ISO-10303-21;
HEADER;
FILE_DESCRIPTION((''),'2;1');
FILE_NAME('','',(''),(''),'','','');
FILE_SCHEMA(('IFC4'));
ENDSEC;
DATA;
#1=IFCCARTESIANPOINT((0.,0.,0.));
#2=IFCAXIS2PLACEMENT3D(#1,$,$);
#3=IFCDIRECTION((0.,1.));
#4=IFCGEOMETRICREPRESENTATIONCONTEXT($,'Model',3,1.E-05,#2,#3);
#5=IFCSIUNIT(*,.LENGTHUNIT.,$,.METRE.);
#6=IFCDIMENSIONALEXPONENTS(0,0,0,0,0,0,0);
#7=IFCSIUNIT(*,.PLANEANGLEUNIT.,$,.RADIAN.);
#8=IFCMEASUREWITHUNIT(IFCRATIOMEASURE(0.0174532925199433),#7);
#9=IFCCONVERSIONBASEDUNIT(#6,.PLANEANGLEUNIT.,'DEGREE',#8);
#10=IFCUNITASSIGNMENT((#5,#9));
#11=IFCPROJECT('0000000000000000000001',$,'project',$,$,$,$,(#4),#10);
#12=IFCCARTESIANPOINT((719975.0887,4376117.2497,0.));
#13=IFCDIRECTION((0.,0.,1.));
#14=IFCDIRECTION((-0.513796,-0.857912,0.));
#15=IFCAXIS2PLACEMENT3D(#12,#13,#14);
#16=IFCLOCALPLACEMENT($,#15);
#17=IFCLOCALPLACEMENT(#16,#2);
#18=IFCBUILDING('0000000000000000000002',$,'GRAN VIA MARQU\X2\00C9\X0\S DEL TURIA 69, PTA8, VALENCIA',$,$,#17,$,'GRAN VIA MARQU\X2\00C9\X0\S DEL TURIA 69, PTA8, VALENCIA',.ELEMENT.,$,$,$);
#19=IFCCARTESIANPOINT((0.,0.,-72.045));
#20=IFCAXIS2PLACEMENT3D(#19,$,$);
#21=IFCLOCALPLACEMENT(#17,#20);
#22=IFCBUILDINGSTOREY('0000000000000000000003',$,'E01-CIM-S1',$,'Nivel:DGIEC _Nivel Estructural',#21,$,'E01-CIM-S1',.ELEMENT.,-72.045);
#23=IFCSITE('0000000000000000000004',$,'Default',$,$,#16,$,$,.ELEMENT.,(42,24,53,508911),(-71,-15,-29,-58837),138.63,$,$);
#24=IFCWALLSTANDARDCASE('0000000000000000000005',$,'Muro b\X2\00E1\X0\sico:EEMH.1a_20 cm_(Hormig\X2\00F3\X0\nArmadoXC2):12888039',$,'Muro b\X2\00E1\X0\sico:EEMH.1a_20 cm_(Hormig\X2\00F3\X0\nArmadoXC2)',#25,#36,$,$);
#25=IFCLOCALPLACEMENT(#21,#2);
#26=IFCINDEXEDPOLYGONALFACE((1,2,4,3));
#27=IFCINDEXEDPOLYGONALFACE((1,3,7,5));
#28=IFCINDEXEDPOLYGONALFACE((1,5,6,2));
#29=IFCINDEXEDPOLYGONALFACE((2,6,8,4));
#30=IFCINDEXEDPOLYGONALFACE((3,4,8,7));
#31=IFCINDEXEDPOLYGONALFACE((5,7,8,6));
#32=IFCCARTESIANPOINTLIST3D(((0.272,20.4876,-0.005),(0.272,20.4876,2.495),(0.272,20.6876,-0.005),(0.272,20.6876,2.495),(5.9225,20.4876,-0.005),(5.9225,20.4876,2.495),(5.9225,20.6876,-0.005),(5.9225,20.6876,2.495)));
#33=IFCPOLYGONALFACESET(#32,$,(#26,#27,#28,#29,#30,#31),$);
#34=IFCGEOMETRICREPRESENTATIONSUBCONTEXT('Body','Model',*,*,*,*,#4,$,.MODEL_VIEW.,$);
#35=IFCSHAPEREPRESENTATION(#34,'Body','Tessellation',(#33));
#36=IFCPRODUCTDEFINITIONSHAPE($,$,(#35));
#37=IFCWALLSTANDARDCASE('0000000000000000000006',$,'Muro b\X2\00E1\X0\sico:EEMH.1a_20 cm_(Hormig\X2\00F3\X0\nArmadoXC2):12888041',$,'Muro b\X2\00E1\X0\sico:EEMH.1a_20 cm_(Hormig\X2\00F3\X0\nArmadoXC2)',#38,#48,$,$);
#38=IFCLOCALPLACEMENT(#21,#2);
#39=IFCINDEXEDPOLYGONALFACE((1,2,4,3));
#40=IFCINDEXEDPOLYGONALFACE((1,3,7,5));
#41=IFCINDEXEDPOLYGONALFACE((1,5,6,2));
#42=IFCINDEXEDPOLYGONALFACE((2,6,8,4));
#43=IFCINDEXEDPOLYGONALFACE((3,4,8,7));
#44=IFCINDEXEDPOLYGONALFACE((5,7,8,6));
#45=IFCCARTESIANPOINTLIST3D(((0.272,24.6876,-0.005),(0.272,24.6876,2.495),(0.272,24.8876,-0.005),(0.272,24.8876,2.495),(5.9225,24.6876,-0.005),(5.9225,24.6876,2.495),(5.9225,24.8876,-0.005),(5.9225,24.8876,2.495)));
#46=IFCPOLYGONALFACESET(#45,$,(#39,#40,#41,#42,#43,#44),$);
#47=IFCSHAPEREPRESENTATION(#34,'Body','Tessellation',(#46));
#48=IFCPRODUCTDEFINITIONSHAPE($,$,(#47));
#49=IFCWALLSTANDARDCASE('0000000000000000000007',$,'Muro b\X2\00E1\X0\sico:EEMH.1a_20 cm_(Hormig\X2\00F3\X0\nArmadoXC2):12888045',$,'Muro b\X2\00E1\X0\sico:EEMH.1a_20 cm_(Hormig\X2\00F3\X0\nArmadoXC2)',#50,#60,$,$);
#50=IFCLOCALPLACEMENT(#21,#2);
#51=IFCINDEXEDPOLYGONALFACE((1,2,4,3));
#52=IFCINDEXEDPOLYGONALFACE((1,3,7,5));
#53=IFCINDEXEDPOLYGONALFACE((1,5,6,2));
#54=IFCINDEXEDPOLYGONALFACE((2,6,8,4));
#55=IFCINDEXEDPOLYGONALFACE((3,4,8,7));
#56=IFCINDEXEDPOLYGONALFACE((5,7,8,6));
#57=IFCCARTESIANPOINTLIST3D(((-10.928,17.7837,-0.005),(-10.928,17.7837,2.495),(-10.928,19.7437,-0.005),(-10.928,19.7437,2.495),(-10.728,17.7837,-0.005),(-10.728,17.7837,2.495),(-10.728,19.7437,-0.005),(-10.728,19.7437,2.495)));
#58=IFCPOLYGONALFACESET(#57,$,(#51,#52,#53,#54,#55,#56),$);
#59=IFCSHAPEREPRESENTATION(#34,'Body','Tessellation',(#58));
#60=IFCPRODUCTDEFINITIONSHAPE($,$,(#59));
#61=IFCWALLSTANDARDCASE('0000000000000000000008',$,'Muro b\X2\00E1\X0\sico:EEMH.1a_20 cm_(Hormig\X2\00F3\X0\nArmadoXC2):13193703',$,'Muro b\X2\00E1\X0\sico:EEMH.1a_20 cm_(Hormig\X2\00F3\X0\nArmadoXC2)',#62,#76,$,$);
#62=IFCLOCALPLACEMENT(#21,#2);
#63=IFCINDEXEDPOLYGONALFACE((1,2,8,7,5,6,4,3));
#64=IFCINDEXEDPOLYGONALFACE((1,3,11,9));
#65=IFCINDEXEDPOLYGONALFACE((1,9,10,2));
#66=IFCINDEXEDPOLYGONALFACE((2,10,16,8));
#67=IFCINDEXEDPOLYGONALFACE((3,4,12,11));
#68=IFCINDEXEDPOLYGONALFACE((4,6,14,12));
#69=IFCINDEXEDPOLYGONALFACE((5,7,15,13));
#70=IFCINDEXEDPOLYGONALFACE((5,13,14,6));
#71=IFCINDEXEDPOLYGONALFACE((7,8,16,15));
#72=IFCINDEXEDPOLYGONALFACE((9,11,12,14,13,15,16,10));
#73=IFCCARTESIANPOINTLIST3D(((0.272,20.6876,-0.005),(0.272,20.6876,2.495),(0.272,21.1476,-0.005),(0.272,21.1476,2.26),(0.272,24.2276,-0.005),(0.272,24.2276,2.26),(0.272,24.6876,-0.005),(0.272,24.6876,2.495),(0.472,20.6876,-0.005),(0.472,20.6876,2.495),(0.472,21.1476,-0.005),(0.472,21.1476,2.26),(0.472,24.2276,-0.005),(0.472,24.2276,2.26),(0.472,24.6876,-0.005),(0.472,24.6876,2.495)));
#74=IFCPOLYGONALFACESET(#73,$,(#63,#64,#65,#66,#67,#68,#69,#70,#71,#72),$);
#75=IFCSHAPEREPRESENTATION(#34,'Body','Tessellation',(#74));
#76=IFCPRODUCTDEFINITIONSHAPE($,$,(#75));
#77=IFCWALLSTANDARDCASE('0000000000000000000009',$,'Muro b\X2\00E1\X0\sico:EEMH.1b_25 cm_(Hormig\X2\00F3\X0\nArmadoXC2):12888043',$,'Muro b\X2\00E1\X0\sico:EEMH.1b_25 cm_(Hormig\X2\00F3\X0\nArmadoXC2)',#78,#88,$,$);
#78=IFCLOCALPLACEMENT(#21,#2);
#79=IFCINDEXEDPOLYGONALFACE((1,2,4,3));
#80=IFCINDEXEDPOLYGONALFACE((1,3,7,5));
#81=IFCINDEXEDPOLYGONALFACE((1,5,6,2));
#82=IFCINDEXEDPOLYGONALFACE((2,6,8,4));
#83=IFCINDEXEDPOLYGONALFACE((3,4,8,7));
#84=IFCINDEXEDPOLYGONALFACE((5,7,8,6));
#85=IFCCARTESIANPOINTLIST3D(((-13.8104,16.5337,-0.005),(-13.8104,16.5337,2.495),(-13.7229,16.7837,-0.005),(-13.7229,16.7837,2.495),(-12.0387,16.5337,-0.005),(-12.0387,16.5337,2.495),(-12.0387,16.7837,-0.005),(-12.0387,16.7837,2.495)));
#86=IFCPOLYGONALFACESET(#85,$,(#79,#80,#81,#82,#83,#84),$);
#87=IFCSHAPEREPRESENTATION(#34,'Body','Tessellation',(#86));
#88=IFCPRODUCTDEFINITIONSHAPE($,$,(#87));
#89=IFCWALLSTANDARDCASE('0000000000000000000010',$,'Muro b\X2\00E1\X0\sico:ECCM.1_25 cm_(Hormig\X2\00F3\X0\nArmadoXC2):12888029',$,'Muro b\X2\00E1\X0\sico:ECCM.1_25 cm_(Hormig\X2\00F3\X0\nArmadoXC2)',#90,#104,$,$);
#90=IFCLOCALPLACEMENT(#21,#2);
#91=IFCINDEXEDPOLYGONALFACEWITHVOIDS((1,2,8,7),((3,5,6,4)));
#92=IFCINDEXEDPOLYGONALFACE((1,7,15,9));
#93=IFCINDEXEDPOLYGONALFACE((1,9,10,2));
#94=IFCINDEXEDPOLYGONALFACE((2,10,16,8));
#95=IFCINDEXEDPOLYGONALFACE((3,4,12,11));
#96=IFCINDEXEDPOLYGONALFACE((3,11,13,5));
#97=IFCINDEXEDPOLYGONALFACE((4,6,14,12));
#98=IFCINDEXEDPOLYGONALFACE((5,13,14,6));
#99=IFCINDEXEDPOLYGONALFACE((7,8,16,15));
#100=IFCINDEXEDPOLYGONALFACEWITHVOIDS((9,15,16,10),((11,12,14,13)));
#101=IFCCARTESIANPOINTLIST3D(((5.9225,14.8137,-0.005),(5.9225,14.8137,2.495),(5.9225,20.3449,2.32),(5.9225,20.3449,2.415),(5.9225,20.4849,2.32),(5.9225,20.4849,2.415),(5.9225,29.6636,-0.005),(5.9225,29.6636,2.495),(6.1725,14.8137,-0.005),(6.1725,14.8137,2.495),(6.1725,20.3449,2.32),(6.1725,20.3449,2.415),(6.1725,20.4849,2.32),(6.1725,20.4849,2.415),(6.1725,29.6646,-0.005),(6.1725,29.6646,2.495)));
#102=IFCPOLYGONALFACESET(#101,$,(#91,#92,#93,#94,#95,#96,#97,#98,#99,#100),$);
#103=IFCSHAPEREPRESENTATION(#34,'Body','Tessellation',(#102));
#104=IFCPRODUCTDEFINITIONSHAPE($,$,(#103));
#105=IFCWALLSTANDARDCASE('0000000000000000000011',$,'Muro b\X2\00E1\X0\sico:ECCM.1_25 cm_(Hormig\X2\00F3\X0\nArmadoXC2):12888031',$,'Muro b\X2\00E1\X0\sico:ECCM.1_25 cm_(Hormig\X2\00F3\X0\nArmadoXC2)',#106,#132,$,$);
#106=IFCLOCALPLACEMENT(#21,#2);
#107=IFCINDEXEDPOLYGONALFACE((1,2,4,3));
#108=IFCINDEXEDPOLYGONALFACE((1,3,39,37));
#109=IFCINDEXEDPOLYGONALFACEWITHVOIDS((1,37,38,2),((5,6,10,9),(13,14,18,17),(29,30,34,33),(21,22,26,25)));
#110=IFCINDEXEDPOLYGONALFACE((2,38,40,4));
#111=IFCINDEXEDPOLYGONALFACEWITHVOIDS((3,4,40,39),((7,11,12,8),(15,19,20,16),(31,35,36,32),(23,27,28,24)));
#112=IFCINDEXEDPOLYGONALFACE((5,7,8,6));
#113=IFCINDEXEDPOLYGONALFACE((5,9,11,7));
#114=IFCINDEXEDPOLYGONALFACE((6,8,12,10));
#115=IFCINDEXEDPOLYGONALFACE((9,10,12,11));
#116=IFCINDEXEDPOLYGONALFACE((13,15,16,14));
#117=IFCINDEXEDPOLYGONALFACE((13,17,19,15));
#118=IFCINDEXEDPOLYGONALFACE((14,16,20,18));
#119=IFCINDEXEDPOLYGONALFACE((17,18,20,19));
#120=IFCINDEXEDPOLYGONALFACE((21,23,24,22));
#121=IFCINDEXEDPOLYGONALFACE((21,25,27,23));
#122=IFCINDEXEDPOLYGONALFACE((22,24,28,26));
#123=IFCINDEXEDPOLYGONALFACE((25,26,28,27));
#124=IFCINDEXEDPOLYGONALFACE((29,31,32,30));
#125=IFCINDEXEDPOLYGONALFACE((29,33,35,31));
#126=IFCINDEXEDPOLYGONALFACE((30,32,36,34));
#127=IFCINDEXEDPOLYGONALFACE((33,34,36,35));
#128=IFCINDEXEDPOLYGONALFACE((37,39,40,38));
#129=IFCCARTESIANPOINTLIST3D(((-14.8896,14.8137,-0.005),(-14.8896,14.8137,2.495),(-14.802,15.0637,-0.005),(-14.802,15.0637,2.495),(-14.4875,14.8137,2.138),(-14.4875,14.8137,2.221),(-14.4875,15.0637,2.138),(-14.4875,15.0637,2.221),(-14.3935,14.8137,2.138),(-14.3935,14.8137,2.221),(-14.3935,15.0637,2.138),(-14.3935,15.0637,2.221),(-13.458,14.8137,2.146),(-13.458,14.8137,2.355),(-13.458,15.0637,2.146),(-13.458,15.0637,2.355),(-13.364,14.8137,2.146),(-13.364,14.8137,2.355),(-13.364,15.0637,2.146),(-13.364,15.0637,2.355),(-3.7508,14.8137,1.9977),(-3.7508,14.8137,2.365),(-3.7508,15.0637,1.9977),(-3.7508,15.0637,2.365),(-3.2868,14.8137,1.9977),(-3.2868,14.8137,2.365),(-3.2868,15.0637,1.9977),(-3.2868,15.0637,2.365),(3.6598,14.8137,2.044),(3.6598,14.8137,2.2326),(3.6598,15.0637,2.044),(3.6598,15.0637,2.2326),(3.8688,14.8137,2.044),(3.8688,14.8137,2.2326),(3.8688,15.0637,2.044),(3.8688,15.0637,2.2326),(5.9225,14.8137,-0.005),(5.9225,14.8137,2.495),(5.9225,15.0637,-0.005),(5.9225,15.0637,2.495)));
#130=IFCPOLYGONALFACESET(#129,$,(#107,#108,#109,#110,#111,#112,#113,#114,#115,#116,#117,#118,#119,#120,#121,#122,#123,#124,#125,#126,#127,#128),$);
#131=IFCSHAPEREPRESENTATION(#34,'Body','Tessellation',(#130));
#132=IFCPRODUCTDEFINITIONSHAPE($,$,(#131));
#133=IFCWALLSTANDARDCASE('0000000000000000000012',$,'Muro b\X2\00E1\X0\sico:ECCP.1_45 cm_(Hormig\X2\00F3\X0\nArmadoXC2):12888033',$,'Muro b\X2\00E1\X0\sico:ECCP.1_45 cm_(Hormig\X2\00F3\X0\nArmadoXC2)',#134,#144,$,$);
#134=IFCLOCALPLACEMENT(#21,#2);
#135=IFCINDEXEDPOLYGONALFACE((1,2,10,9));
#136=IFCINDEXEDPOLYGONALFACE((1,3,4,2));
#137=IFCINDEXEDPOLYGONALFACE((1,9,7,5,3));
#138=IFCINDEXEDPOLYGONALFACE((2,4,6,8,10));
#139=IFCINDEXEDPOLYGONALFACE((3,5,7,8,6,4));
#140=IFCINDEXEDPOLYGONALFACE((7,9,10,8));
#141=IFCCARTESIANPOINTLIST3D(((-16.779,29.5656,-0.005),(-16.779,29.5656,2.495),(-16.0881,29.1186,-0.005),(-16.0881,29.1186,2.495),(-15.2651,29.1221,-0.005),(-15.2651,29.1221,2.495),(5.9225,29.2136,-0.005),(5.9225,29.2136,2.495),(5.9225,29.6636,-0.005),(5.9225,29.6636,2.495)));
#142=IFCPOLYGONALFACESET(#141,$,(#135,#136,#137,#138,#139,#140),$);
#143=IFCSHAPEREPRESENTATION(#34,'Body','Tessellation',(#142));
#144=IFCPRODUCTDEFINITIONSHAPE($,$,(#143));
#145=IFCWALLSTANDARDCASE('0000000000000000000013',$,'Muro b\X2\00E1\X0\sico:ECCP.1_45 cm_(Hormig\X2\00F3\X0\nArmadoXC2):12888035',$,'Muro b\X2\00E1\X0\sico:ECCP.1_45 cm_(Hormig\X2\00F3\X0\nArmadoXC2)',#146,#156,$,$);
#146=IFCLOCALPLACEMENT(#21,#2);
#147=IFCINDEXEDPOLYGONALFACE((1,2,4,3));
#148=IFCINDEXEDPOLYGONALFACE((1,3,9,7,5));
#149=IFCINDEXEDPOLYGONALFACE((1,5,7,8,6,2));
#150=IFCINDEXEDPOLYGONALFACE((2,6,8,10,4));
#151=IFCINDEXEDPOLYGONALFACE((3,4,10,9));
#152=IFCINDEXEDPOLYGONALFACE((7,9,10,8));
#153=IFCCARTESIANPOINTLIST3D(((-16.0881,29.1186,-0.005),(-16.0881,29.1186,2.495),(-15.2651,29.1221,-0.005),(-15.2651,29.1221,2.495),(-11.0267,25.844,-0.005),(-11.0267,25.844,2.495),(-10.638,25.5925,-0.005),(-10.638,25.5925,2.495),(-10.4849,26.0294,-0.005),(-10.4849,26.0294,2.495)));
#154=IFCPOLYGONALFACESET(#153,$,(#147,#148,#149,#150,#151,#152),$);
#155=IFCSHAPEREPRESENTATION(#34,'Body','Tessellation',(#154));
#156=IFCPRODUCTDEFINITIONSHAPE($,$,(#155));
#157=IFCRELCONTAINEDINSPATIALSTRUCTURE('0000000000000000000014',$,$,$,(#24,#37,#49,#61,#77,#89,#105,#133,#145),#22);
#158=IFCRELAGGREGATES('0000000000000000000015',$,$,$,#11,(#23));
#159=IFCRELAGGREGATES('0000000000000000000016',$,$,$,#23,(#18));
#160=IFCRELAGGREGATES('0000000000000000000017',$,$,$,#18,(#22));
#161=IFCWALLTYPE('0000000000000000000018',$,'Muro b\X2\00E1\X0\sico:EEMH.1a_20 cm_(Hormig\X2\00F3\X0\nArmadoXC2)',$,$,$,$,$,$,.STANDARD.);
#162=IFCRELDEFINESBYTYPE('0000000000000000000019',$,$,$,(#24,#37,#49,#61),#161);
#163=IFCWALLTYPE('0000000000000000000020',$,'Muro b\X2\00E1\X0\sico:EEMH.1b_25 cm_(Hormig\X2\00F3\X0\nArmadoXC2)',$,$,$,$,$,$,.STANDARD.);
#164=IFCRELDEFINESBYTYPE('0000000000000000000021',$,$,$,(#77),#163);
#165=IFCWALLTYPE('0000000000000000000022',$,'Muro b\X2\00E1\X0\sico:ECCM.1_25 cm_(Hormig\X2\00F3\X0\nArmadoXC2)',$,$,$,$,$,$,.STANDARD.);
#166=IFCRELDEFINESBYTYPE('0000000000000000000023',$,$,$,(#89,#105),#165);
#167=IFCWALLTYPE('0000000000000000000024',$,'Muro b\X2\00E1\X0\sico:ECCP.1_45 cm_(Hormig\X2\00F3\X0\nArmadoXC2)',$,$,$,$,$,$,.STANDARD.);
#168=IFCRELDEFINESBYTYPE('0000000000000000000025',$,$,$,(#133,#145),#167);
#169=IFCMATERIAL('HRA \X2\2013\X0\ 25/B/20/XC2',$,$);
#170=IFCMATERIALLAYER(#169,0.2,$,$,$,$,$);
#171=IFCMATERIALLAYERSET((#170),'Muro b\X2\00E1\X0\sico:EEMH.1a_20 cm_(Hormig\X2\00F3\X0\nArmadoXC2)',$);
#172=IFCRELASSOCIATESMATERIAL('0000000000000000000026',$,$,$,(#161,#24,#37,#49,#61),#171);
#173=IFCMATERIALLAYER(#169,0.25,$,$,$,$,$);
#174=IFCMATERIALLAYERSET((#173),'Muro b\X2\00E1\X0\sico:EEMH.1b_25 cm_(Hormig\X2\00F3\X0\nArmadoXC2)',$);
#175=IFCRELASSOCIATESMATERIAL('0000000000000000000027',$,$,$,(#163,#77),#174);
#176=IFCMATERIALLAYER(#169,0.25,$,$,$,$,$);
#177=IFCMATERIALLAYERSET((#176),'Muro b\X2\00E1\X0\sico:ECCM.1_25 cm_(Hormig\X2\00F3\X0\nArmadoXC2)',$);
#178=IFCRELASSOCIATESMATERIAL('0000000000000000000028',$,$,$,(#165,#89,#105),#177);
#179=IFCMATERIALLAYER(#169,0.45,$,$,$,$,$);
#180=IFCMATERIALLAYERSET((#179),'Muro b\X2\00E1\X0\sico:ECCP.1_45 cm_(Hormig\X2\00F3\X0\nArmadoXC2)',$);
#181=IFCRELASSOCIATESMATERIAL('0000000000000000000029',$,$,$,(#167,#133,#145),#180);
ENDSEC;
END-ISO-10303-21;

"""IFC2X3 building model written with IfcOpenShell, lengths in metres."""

from ifc_helpers import new_model, entity, si_unit, converted_unit, direction, frame, frame_2d, origin, origin_2d_with_axis, place, context, subcontext, project, spatial, polyline, rectangle, outline, extrude, material, layer, layer_set, layer_usage, type_object, element, save


model = new_model("IFC2X3")

# Units and contexts
model_context = context("Model", 3, precision=1e-05, world=origin(), true_north=direction((0.0, 1.0)))
body_context = subcontext(model_context, "Body", "Model", "MODEL_VIEW")
ifc_project = project(units=[si_unit("LENGTHUNIT", "METRE"), converted_unit("PLANEANGLEUNIT", "DEGREE", entity("IfcRatioMeasure", 0.0174532925199433), si_unit("PLANEANGLEUNIT", "RADIAN"), dimensions=[0, 0, 0, 0, 0, 0, 0])], contexts=[model_context])

# Site, building, storey
site_placement = place(None, frame((719975.0887, 4376117.2497, 0.0), z_axis=(0.0, 0.0, 1.0), x_axis=(-0.513796, -0.857912, 0.0)))
site = spatial("IfcSite", under=ifc_project, at=site_placement, Name="Default", CompositionType="ELEMENT", RefLatitude=(42, 24, 53, 508911), RefLongitude=(-71, -15, -29, -58837), RefElevation=138.63)
building_placement = place(site_placement, origin())
building = spatial("IfcBuilding", under=site, at=building_placement, Name="GRAN VIA MARQUÉS DEL TURIA 69, PTA8, VALENCIA", LongName="GRAN VIA MARQUÉS DEL TURIA 69, PTA8, VALENCIA", CompositionType="ELEMENT")
storey_placement = place(building_placement, frame((0.0, 0.0, -72.045)))
storey = spatial("IfcBuildingStorey", under=building, at=storey_placement, Name="E01-CIM-S1", ObjectType="Nivel:DGIEC _Nivel Estructural", LongName="E01-CIM-S1", CompositionType="ELEMENT", Elevation=-72.045)

# Shared definitions
ifc_material = material(Name="HRA – 25/B/20/XC2")

# Walls
ifc_layer_1 = layer(ifc_material, 0.2)
ifc_layer_set_1 = layer_set([ifc_layer_1], Name="Muro básico:EEMH.1a_20 cm_(HormigónArmadoXC2)")
ifc_layer_usage_1 = layer_usage(ifc_layer_set_1, "AXIS2", "NEGATIVE", 0.1)
wall_type_1 = type_object("IfcWallType", Name="Muro básico:EEMH.1a_20 cm_(HormigónArmadoXC2)", PredefinedType="STANDARD", material=ifc_layer_set_1)
wall_1_placement = place(storey_placement, frame((0.272, 20.5876, -0.005)))
element("IfcWallStandardCase", 1, at=wall_1_placement, inside=storey, type_object=wall_type_1, material=ifc_layer_usage_1, Name="Muro básico:EEMH.1a_20 cm_(HormigónArmadoXC2):12888039", ObjectType="Muro básico:EEMH.1a_20 cm_(HormigónArmadoXC2)", context=body_context, shape_type="SweptSolid", body=[
    extrude(rectangle(XDim=5.6506, YDim=0.2, at=frame_2d((2.8253, 0.0), x_axis=(-1.0, 0.0))), origin(), (0.0, 0.0, 1.0), 2.5),
])
ifc_layer_usage_2 = layer_usage(ifc_layer_set_1, "AXIS2", "NEGATIVE", 0.1)
wall_2_placement = place(storey_placement, frame((0.272, 24.7876, -0.005)))
element("IfcWallStandardCase", 2, at=wall_2_placement, inside=storey, type_object=wall_type_1, material=ifc_layer_usage_2, Name="Muro básico:EEMH.1a_20 cm_(HormigónArmadoXC2):12888041", ObjectType="Muro básico:EEMH.1a_20 cm_(HormigónArmadoXC2)", context=body_context, shape_type="SweptSolid", body=[
    extrude(rectangle(XDim=5.6506, YDim=0.2, at=frame_2d((2.8253, 0.0), x_axis=(-1.0, 0.0))), origin(), (0.0, 0.0, 1.0), 2.5),
])
ifc_layer_usage_3 = layer_usage(ifc_layer_set_1, "AXIS2", "NEGATIVE", 0.1)
wall_3_placement = place(storey_placement, frame((-10.828, 17.7837, -0.005), z_axis=(0.0, 0.0, 1.0), x_axis=(0.0, 1.0, 0.0)))
element("IfcWallStandardCase", 3, at=wall_3_placement, inside=storey, type_object=wall_type_1, material=ifc_layer_usage_3, Name="Muro básico:EEMH.1a_20 cm_(HormigónArmadoXC2):12888045", ObjectType="Muro básico:EEMH.1a_20 cm_(HormigónArmadoXC2)", context=body_context, shape_type="SweptSolid", body=[
    extrude(rectangle(XDim=1.96, YDim=0.2, at=frame_2d((0.98, 0.0), x_axis=(-1.0, 0.0))), origin(), (0.0, 0.0, 1.0), 2.5),
])

# Wall, opening
ifc_layer_usage_4 = layer_usage(ifc_layer_set_1, "AXIS2", "POSITIVE", -0.1)
wall_4_placement = place(storey_placement, frame((0.372, 24.6876, -0.005), z_axis=(0.0, 0.0, 1.0), x_axis=(0.0, -1.0, 0.0)))
wall_4 = element("IfcWallStandardCase", 4, at=wall_4_placement, inside=storey, type_object=wall_type_1, material=ifc_layer_usage_4, Name="Muro básico:EEMH.1a_20 cm_(HormigónArmadoXC2):13193703", ObjectType="Muro básico:EEMH.1a_20 cm_(HormigónArmadoXC2)", context=body_context, shape_type="SweptSolid", body=[
    extrude(rectangle(XDim=4.0, YDim=0.2, at=frame_2d((2.0, 0.0), x_axis=(-1.0, 0.0))), origin(), (0.0, 0.0, 1.0), 2.5),
])
opening_1_placement = place(wall_4_placement, origin())
element("IfcOpeningElement", 5, at=opening_1_placement, cuts=wall_4, ObjectType="Opening", context=body_context, shape_type="SweptSolid", body=[
    extrude(rectangle(XDim=2.265, YDim=3.08, at=origin_2d_with_axis()), frame((2.0, -0.1, 1.1325), z_axis=(0.0, 1.0, 0.0), x_axis=(0.0, 0.0, -1.0)), (0.0, 0.0, 1.0), 0.2),
])

# Wall
ifc_layer_2 = layer(ifc_material, 0.25)
ifc_layer_set_2 = layer_set([ifc_layer_2], Name="Muro básico:EEMH.1b_25 cm_(HormigónArmadoXC2)")
ifc_layer_usage_5 = layer_usage(ifc_layer_set_2, "AXIS2", "NEGATIVE", 0.125)
wall_type_2 = type_object("IfcWallType", Name="Muro básico:EEMH.1b_25 cm_(HormigónArmadoXC2)", PredefinedType="STANDARD", material=ifc_layer_set_2)
wall_5_placement = place(storey_placement, frame((-12.0387, 16.6587, -0.005), z_axis=(0.0, 0.0, 1.0), x_axis=(-1.0, 0.0, 0.0)))
element("IfcWallStandardCase", 6, at=wall_5_placement, inside=storey, type_object=wall_type_2, material=ifc_layer_usage_5, Name="Muro básico:EEMH.1b_25 cm_(HormigónArmadoXC2):12888043", ObjectType="Muro básico:EEMH.1b_25 cm_(HormigónArmadoXC2)", context=body_context, shape_type="SweptSolid", body=[
    extrude(outline(polyline([(1.6841, -0.125), (1.7717, 0.125), (0.0, 0.125), (0.0, -0.125), (1.6841, -0.125)])), origin(), (0.0, 0.0, 1.0), 2.5),
])

# Wall, opening
ifc_layer_3 = layer(ifc_material, 0.25)
ifc_layer_set_3 = layer_set([ifc_layer_3], Name="Muro básico:ECCM.1_25 cm_(HormigónArmadoXC2)")
ifc_layer_usage_6 = layer_usage(ifc_layer_set_3, "AXIS2", "NEGATIVE", 0.125)
wall_type_3 = type_object("IfcWallType", Name="Muro básico:ECCM.1_25 cm_(HormigónArmadoXC2)", PredefinedType="STANDARD", material=ifc_layer_set_3)
wall_6_placement = place(storey_placement, frame((6.0475, 29.6646, -0.005), z_axis=(0.0, 0.0, 1.0), x_axis=(0.0, -1.0, 0.0)))
wall_6 = element("IfcWallStandardCase", 7, at=wall_6_placement, inside=storey, type_object=wall_type_3, material=ifc_layer_usage_6, Name="Muro básico:ECCM.1_25 cm_(HormigónArmadoXC2):12888029", ObjectType="Muro básico:ECCM.1_25 cm_(HormigónArmadoXC2)", context=body_context, shape_type="SweptSolid", body=[
    extrude(outline(polyline([(14.8509, -0.125), (14.8509, 0.125), (0.0, 0.125), (0.0011, -0.125), (0.4511, -0.125), (4.7771, -0.125), (4.9771, -0.125), (8.9771, -0.125), (9.1771, -0.125), (14.6009, -0.125), (14.8509, -0.125)])), origin(), (0.0, 0.0, 1.0), 2.5),
])
opening_2_placement = place(wall_6_placement, origin())
element("IfcOpeningElement", 8, at=opening_2_placement, cuts=wall_6, ObjectType="Opening", context=body_context, shape_type="SweptSolid", body=[
    extrude(rectangle(XDim=0.095, YDim=0.14, at=frame_2d((0.0, 0.0), x_axis=(1.0, 0.0))), frame((9.2497, -0.125, 2.3725), z_axis=(0.0, 1.0, 0.0), x_axis=(0.0, 0.0, -1.0)), (0.0, 0.0, 1.0), 0.25),
])

# Wall, openings
ifc_layer_usage_7 = layer_usage(ifc_layer_set_3, "AXIS2", "NEGATIVE", 0.125)
wall_7_placement = place(storey_placement, frame((5.9225, 14.9387, -0.005), z_axis=(0.0, 0.0, 1.0), x_axis=(-1.0, 0.0, 0.0)))
wall_7 = element("IfcWallStandardCase", 9, at=wall_7_placement, inside=storey, type_object=wall_type_3, material=ifc_layer_usage_7, Name="Muro básico:ECCM.1_25 cm_(HormigónArmadoXC2):12888031", ObjectType="Muro básico:ECCM.1_25 cm_(HormigónArmadoXC2)", context=body_context, shape_type="SweptSolid", body=[
    extrude(outline(polyline([(20.7246, -0.125), (20.8121, 0.125), (0.0, 0.125), (0.0, -0.125), (20.2478, -0.125), (20.7246, -0.125)])), origin(), (0.0, 0.0, 1.0), 2.5),
])
opening_3_placement = place(wall_7_placement, origin())
element("IfcOpeningElement", 10, at=opening_3_placement, cuts=wall_7, ObjectType="Opening", context=body_context, shape_type="SweptSolid", body=[
    extrude(rectangle(XDim=0.3673, YDim=0.464, at=frame_2d((0.0, 0.0), x_axis=(1.0, 0.0))), frame((9.4413, -0.125, 2.1864), z_axis=(0.0, 1.0, 0.0), x_axis=(0.0, 0.0, -1.0)), (0.0, 0.0, 1.0), 0.25),
])
opening_4_placement = place(wall_7_placement, origin())
element("IfcOpeningElement", 11, at=opening_4_placement, cuts=wall_7, ObjectType="Opening", context=body_context, shape_type="SweptSolid", body=[
    extrude(rectangle(XDim=0.083, YDim=0.094, at=origin_2d_with_axis()), frame((20.363, -0.125, 2.1845), z_axis=(0.0, 1.0, 0.0), x_axis=(0.0, 0.0, -1.0)), (0.0, 0.0, 1.0), 0.25),
])
opening_5_placement = place(wall_7_placement, origin())
element("IfcOpeningElement", 12, at=opening_5_placement, cuts=wall_7, ObjectType="Opening", context=body_context, shape_type="SweptSolid", body=[
    extrude(rectangle(XDim=0.1886, YDim=0.209, at=frame_2d((0.0, 0.0), x_axis=(1.0, 0.0))), frame((2.1583, -0.125, 2.1433), z_axis=(0.0, 1.0, 0.0), x_axis=(0.0, 0.0, -1.0)), (0.0, 0.0, 1.0), 0.25),
])
opening_6_placement = place(wall_7_placement, origin())
element("IfcOpeningElement", 13, at=opening_6_placement, cuts=wall_7, ObjectType="Opening", context=body_context, shape_type="SweptSolid", body=[
    extrude(rectangle(XDim=0.209, YDim=0.094, at=frame_2d((0.0, 0.0), x_axis=(1.0, 0.0))), frame((19.3336, -0.125, 2.2555), z_axis=(0.0, 1.0, 0.0), x_axis=(0.0, 0.0, -1.0)), (0.0, 0.0, 1.0), 0.25),
])

# Walls
ifc_layer_4 = layer(ifc_material, 0.45)
ifc_layer_set_4 = layer_set([ifc_layer_4], Name="Muro básico:ECCP.1_45 cm_(HormigónArmadoXC2)")
ifc_layer_usage_8 = layer_usage(ifc_layer_set_4, "AXIS2", "NEGATIVE", 0.225)
wall_type_4 = type_object("IfcWallType", Name="Muro básico:ECCP.1_45 cm_(HormigónArmadoXC2)", PredefinedType="STANDARD", material=ifc_layer_set_4)
wall_8_placement = place(storey_placement, frame((-16.778, 29.3406, -0.005), z_axis=(0.0, 0.0, 1.0), x_axis=(0.999991, 0.004316, 0.0)))
element("IfcWallStandardCase", 14, at=wall_8_placement, inside=storey, type_object=wall_type_4, material=ifc_layer_usage_8, Name="Muro básico:ECCP.1_45 cm_(HormigónArmadoXC2):12888033", ObjectType="Muro básico:ECCP.1_45 cm_(HormigónArmadoXC2)", context=body_context, shape_type="SweptSolid", body=[
    extrude(outline(polyline([(22.6998, -0.225), (22.7018, 0.225), (0.0, 0.225), (0.689, -0.225), (1.5119, -0.225), (22.6998, -0.225)])), origin(), (0.0, 0.0, 1.0), 2.5),
])
ifc_layer_usage_9 = layer_usage(ifc_layer_set_4, "AXIS2", "NEGATIVE", 0.225)
wall_9_placement = place(storey_placement, frame((-10.5157, 25.7814, -0.005), z_axis=(0.0, 0.0, 1.0), x_axis=(-0.839602, 0.543202, 0.0)))
element("IfcWallStandardCase", 15, at=wall_9_placement, inside=storey, type_object=wall_type_4, material=ifc_layer_usage_9, Name="Muro básico:ECCP.1_45 cm_(HormigónArmadoXC2):12888035", ObjectType="Muro básico:ECCP.1_45 cm_(HormigónArmadoXC2)", context=body_context, shape_type="SweptSolid", body=[
    extrude(outline(polyline([(5.8023, -0.225), (6.4913, 0.225), (0.463, 0.225), (0.0, 0.225), (0.1089, -0.225), (5.8023, -0.225)])), origin(), (0.0, 0.0, 1.0), 2.5),
])

save(model, "model.ifc")
